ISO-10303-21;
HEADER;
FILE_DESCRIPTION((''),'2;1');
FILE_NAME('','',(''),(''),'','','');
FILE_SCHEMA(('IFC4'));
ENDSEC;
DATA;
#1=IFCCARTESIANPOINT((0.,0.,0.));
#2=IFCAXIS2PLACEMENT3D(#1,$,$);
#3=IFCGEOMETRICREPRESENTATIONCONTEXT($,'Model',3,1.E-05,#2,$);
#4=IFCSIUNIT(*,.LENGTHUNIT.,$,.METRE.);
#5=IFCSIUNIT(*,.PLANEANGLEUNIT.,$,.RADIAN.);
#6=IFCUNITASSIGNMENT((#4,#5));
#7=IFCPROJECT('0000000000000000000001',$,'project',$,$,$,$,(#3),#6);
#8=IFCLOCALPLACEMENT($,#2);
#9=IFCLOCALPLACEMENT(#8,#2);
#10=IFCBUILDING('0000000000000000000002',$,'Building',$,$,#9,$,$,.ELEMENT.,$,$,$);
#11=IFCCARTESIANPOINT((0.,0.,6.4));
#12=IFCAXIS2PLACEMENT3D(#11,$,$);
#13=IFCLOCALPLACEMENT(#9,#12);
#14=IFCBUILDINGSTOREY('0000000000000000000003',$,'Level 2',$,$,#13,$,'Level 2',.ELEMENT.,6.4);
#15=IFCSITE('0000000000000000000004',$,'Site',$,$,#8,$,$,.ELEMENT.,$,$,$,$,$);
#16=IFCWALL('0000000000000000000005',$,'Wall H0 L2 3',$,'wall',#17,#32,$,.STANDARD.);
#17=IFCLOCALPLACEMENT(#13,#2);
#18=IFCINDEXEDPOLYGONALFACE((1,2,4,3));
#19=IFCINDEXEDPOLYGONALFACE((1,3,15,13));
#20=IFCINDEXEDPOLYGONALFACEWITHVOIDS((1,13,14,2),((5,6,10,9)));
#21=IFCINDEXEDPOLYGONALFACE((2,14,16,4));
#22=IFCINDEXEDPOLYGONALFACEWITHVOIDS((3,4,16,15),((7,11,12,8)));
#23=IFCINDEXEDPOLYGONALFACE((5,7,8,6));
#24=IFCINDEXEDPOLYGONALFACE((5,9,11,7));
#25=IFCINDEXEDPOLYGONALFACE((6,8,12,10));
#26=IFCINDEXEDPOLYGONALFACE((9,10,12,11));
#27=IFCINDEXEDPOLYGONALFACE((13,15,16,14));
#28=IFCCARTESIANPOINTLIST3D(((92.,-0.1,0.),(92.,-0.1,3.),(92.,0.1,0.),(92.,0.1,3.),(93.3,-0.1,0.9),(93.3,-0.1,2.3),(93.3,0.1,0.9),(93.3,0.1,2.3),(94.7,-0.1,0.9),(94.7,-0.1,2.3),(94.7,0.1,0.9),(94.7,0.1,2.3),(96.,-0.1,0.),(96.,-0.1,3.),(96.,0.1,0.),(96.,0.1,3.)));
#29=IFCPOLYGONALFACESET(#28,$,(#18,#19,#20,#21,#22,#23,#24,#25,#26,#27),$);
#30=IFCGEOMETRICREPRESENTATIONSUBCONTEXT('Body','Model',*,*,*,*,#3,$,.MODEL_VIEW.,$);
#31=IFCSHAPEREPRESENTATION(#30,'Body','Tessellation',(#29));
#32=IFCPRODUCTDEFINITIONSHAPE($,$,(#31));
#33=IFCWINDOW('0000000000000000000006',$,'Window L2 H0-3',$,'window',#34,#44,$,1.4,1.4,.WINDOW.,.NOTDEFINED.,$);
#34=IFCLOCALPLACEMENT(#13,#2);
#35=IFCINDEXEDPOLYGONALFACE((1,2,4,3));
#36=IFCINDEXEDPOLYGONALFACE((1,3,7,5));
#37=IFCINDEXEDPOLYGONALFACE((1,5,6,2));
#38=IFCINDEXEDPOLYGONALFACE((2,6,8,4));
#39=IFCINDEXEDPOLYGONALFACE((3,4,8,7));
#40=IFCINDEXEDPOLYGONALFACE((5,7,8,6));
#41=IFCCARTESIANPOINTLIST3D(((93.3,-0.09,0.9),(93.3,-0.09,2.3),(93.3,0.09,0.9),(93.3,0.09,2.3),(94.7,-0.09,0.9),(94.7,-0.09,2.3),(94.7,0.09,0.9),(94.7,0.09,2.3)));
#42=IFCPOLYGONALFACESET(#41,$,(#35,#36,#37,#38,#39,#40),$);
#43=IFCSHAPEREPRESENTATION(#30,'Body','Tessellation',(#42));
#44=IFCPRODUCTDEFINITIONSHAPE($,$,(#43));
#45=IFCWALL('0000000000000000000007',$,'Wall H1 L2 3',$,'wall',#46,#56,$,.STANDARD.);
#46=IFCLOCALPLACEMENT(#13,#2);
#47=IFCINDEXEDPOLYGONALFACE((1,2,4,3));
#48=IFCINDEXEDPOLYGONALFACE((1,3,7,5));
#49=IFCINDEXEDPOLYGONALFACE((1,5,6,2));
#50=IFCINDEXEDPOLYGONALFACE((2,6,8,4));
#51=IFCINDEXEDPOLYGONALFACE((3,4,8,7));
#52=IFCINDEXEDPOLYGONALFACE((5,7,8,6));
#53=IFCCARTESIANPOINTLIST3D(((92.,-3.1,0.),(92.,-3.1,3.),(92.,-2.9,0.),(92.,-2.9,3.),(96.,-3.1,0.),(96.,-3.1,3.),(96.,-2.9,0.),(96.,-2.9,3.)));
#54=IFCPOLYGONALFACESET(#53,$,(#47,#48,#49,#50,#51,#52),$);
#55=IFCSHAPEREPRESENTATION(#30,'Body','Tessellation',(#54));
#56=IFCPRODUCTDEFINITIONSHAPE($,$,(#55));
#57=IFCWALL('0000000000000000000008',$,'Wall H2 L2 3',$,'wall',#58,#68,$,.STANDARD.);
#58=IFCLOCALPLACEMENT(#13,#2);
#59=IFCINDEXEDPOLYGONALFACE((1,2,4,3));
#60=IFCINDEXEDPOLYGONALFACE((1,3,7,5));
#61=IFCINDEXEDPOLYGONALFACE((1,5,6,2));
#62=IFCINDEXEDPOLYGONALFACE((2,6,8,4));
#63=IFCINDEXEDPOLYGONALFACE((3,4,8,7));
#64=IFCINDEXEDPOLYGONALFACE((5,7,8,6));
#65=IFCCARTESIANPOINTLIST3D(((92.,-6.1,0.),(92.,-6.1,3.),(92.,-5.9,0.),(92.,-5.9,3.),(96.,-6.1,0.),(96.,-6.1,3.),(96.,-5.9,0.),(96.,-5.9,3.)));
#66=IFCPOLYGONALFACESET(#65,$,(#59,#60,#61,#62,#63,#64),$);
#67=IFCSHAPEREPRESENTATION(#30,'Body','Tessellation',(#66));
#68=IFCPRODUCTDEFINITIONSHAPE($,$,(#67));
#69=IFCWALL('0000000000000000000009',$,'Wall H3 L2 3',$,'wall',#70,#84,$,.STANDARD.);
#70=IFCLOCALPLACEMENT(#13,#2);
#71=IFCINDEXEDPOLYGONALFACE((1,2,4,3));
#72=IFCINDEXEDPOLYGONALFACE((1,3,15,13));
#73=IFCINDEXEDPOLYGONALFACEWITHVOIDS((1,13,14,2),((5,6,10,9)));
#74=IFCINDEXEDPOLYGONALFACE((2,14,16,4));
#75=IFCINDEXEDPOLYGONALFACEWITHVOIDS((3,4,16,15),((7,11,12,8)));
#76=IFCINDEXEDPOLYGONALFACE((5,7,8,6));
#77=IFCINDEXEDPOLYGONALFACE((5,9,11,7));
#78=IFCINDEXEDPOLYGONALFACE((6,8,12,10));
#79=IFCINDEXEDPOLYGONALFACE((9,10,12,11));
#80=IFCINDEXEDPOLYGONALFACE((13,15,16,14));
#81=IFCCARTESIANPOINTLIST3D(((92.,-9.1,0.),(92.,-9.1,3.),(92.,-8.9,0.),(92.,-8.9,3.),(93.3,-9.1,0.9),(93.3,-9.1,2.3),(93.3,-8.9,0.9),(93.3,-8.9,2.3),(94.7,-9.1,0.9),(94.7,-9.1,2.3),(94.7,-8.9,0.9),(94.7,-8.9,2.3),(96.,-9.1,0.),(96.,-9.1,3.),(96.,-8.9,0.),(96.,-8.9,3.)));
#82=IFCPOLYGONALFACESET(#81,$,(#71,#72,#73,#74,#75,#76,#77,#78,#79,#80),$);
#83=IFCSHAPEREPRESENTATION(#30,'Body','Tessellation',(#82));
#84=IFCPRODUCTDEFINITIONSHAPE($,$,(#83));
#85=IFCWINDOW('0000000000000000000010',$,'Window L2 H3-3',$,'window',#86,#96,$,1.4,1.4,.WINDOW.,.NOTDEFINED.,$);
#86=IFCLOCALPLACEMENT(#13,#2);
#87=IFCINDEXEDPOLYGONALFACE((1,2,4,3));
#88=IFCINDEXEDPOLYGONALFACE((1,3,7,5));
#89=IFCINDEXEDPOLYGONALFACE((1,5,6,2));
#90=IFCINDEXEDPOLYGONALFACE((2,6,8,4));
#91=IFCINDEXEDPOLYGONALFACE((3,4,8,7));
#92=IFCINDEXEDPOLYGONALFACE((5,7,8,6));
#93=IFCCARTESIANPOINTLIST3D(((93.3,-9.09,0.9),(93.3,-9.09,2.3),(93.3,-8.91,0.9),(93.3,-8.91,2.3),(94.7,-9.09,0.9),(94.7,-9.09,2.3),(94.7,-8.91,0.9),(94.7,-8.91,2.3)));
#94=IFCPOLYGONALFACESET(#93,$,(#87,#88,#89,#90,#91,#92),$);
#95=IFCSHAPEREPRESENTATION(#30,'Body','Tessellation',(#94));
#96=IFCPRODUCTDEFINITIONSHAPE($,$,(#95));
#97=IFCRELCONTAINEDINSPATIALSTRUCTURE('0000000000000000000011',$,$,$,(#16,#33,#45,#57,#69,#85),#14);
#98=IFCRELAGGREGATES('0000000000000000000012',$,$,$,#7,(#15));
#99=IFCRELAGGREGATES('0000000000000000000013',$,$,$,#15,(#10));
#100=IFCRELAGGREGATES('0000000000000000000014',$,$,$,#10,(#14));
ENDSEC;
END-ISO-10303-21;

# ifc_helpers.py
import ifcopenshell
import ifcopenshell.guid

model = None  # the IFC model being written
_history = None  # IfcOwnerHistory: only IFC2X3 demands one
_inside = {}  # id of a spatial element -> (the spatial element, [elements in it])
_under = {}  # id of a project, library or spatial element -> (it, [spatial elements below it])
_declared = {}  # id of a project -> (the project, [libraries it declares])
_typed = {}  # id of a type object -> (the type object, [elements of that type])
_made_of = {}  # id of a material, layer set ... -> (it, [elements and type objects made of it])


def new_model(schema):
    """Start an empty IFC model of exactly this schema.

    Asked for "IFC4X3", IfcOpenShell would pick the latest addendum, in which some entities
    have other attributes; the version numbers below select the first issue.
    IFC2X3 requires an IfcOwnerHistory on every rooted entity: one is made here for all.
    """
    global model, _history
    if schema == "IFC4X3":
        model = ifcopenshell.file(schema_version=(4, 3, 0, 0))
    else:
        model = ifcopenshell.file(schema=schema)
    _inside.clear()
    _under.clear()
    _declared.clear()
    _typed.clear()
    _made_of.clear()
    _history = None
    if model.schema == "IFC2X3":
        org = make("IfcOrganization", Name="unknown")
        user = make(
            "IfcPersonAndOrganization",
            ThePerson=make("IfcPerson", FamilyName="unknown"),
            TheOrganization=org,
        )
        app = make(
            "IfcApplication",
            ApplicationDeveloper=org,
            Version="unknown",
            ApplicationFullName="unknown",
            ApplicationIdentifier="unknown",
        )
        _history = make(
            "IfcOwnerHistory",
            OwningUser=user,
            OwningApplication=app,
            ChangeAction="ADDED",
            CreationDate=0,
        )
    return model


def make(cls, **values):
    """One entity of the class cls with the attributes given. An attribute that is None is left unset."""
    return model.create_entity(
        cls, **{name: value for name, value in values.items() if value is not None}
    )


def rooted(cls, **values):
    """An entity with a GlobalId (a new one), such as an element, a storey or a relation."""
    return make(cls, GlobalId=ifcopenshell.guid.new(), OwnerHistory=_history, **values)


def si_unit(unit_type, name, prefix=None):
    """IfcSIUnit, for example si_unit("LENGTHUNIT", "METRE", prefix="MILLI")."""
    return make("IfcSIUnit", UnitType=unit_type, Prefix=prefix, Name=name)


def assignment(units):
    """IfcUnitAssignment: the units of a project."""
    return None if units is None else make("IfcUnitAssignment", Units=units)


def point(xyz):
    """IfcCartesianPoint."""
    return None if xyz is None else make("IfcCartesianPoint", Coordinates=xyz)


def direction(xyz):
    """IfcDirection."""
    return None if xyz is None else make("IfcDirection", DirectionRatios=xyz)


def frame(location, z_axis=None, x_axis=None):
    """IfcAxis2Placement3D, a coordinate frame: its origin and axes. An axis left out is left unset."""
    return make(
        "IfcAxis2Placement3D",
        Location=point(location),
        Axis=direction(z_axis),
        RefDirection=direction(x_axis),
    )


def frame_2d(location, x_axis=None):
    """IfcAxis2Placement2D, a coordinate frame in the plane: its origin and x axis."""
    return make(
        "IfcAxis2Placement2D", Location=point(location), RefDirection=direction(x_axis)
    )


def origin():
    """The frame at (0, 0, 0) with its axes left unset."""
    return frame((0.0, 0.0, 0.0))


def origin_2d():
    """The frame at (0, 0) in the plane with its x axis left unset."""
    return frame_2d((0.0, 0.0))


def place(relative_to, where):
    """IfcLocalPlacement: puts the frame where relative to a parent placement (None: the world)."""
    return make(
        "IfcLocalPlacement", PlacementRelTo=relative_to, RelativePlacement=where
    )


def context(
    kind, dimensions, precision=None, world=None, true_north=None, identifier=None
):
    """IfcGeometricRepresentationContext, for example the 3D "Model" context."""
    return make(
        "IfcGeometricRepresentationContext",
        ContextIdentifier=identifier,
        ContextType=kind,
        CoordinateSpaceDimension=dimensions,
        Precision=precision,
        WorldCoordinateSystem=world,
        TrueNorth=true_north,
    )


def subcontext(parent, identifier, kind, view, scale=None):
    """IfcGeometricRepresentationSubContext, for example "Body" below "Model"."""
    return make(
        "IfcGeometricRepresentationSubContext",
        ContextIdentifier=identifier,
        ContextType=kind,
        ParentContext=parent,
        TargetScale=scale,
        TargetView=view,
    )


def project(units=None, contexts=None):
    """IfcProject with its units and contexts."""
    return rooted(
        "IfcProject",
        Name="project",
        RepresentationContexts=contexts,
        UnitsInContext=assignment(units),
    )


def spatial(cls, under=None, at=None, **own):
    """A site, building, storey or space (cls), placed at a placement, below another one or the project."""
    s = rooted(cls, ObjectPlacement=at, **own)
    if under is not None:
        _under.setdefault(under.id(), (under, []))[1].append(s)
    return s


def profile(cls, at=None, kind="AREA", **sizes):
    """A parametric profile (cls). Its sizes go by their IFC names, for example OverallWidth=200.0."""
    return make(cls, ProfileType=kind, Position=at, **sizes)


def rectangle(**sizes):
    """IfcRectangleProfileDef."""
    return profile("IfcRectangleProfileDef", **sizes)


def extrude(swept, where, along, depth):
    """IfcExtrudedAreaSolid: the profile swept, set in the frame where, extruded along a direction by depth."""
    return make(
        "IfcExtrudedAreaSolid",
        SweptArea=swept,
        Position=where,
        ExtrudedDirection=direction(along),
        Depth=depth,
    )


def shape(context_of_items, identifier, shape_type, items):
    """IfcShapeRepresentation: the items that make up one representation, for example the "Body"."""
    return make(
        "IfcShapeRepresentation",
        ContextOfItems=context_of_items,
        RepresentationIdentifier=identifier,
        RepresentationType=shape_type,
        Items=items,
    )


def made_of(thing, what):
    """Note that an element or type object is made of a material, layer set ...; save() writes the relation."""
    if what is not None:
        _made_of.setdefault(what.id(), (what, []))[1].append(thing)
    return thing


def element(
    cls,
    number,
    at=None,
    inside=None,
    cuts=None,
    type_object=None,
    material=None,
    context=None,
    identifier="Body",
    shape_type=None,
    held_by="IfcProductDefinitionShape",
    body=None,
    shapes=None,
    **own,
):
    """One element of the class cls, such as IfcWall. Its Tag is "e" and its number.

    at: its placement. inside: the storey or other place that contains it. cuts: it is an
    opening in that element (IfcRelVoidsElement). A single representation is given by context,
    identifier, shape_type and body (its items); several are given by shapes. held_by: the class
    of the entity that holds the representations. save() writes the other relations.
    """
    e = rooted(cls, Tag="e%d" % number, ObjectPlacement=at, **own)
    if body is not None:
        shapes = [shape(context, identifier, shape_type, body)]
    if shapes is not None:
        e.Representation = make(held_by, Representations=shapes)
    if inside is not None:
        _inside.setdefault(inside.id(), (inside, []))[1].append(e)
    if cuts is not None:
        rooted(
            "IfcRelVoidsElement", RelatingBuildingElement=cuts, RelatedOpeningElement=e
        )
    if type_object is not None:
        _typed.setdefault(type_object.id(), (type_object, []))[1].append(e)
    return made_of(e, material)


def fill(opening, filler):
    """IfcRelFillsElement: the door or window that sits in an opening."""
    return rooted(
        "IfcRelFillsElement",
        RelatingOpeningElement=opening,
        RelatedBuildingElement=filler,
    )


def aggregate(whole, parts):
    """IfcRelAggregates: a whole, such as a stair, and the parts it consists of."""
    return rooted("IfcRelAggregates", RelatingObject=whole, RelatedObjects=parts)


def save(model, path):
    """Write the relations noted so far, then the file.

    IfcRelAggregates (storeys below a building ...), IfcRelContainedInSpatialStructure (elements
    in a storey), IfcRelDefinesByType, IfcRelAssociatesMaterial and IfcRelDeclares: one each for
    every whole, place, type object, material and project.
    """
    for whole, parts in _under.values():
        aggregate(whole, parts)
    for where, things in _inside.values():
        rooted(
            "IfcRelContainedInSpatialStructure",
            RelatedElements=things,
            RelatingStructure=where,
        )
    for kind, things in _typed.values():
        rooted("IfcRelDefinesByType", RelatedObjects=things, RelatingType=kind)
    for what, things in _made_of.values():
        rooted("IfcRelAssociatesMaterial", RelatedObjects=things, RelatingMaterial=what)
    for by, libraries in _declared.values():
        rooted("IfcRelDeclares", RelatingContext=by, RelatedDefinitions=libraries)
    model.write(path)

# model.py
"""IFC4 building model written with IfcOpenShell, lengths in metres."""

from ifc_helpers import new_model, si_unit, frame, frame_2d, origin, origin_2d, place, context, subcontext, project, spatial, rectangle, extrude, element, fill, save


model = new_model("IFC4")

# Units and contexts
model_context = context("Model", 3, precision=1e-05, world=origin())
body_context = subcontext(model_context, "Body", "Model", "MODEL_VIEW")
ifc_project = project(units=[si_unit("LENGTHUNIT", "METRE"), si_unit("PLANEANGLEUNIT", "RADIAN")], contexts=[model_context])

# Site, building, storey
site_placement = place(None, origin())
site = spatial("IfcSite", under=ifc_project, at=site_placement, Name="Site", CompositionType="ELEMENT")
building_placement = place(site_placement, origin())
building = spatial("IfcBuilding", under=site, at=building_placement, Name="Building", CompositionType="ELEMENT")
storey_placement = place(building_placement, frame((0.0, 0.0, 6.4)))
storey = spatial("IfcBuildingStorey", under=building, at=storey_placement, Name="Level 2", LongName="Level 2", CompositionType="ELEMENT", Elevation=6.4)

# Wall, opening, window
wall_1_placement = place(storey_placement, frame((92.0, 0.0, 0.0), z_axis=(0.0, 0.0, 1.0), x_axis=(1.0, 0.0, 0.0)))
wall_1 = element("IfcWall", 1, at=wall_1_placement, inside=storey, Name="Wall H0 L2 3", ObjectType="wall", PredefinedType="STANDARD", context=body_context, shape_type="SweptSolid", body=[
    extrude(rectangle(XDim=4.0, YDim=0.2, at=frame_2d((2.0, 0.0))), origin(), (0.0, 0.0, 1.0), 3.0),
])
opening_1_placement = place(storey_placement, frame((94.0, 0.0, 0.9), z_axis=(0.0, 0.0, 1.0), x_axis=(1.0, 0.0, 0.0)))
opening_1 = element("IfcOpeningElement", 2, at=opening_1_placement, cuts=wall_1, ObjectType="Opening", PredefinedType="OPENING", context=body_context, shape_type="SweptSolid", body=[
    extrude(rectangle(XDim=1.4, YDim=0.22, at=origin_2d()), origin(), (0.0, 0.0, 1.0), 1.4),
])
window_1_placement = place(storey_placement, frame((94.0, 0.0, 0.9), z_axis=(0.0, 0.0, 1.0), x_axis=(1.0, 0.0, 0.0)))
window_1 = element("IfcWindow", 3, at=window_1_placement, inside=storey, Name="Window L2 H0-3", ObjectType="window", OverallHeight=1.4, OverallWidth=1.4, PartitioningType="NOTDEFINED", PredefinedType="WINDOW", context=body_context, shape_type="SweptSolid", body=[
    extrude(rectangle(XDim=1.4, YDim=0.18, at=origin_2d()), origin(), (0.0, 0.0, 1.0), 1.4),
])
fill(opening_1, window_1)

# Walls
for number, where, z_axis, x_axis, name in (
    (4, (92.0, -3.0, 0.0), (0.0, 0.0, 1.0), (1.0, 0.0, 0.0), "Wall H1 L2 3"),
    (5, (92.0, -6.0, 0.0), (0.0, 0.0, 1.0), (1.0, 0.0, 0.0), "Wall H2 L2 3"),
):
    element("IfcWall", number, at=place(storey_placement, frame(where, z_axis=z_axis, x_axis=x_axis)), inside=storey, Name=name, ObjectType="wall", PredefinedType="STANDARD", context=body_context, shape_type="SweptSolid", body=[
        extrude(rectangle(XDim=4.0, YDim=0.2, at=frame_2d((2.0, 0.0))), origin(), (0.0, 0.0, 1.0), 3.0),
    ])

# Wall, opening, window
wall_2_placement = place(storey_placement, frame((92.0, -9.0, 0.0), z_axis=(0.0, 0.0, 1.0), x_axis=(1.0, 0.0, 0.0)))
wall_2 = element("IfcWall", 6, at=wall_2_placement, inside=storey, Name="Wall H3 L2 3", ObjectType="wall", PredefinedType="STANDARD", context=body_context, shape_type="SweptSolid", body=[
    extrude(rectangle(XDim=4.0, YDim=0.2, at=frame_2d((2.0, 0.0))), origin(), (0.0, 0.0, 1.0), 3.0),
])
opening_2_placement = place(storey_placement, frame((94.0, -9.0, 0.9), z_axis=(0.0, 0.0, 1.0), x_axis=(1.0, 0.0, 0.0)))
opening_2 = element("IfcOpeningElement", 7, at=opening_2_placement, cuts=wall_2, ObjectType="Opening", PredefinedType="OPENING", context=body_context, shape_type="SweptSolid", body=[
    extrude(rectangle(XDim=1.4, YDim=0.22, at=origin_2d()), origin(), (0.0, 0.0, 1.0), 1.4),
])
window_2_placement = place(storey_placement, frame((94.0, -9.0, 0.9), z_axis=(0.0, 0.0, 1.0), x_axis=(1.0, 0.0, 0.0)))
window_2 = element("IfcWindow", 8, at=window_2_placement, inside=storey, Name="Window L2 H3-3", ObjectType="window", OverallHeight=1.4, OverallWidth=1.4, PartitioningType="NOTDEFINED", PredefinedType="WINDOW", context=body_context, shape_type="SweptSolid", body=[
    extrude(rectangle(XDim=1.4, YDim=0.18, at=origin_2d()), origin(), (0.0, 0.0, 1.0), 1.4),
])
fill(opening_2, window_2)

save(model, "model.ifc")
